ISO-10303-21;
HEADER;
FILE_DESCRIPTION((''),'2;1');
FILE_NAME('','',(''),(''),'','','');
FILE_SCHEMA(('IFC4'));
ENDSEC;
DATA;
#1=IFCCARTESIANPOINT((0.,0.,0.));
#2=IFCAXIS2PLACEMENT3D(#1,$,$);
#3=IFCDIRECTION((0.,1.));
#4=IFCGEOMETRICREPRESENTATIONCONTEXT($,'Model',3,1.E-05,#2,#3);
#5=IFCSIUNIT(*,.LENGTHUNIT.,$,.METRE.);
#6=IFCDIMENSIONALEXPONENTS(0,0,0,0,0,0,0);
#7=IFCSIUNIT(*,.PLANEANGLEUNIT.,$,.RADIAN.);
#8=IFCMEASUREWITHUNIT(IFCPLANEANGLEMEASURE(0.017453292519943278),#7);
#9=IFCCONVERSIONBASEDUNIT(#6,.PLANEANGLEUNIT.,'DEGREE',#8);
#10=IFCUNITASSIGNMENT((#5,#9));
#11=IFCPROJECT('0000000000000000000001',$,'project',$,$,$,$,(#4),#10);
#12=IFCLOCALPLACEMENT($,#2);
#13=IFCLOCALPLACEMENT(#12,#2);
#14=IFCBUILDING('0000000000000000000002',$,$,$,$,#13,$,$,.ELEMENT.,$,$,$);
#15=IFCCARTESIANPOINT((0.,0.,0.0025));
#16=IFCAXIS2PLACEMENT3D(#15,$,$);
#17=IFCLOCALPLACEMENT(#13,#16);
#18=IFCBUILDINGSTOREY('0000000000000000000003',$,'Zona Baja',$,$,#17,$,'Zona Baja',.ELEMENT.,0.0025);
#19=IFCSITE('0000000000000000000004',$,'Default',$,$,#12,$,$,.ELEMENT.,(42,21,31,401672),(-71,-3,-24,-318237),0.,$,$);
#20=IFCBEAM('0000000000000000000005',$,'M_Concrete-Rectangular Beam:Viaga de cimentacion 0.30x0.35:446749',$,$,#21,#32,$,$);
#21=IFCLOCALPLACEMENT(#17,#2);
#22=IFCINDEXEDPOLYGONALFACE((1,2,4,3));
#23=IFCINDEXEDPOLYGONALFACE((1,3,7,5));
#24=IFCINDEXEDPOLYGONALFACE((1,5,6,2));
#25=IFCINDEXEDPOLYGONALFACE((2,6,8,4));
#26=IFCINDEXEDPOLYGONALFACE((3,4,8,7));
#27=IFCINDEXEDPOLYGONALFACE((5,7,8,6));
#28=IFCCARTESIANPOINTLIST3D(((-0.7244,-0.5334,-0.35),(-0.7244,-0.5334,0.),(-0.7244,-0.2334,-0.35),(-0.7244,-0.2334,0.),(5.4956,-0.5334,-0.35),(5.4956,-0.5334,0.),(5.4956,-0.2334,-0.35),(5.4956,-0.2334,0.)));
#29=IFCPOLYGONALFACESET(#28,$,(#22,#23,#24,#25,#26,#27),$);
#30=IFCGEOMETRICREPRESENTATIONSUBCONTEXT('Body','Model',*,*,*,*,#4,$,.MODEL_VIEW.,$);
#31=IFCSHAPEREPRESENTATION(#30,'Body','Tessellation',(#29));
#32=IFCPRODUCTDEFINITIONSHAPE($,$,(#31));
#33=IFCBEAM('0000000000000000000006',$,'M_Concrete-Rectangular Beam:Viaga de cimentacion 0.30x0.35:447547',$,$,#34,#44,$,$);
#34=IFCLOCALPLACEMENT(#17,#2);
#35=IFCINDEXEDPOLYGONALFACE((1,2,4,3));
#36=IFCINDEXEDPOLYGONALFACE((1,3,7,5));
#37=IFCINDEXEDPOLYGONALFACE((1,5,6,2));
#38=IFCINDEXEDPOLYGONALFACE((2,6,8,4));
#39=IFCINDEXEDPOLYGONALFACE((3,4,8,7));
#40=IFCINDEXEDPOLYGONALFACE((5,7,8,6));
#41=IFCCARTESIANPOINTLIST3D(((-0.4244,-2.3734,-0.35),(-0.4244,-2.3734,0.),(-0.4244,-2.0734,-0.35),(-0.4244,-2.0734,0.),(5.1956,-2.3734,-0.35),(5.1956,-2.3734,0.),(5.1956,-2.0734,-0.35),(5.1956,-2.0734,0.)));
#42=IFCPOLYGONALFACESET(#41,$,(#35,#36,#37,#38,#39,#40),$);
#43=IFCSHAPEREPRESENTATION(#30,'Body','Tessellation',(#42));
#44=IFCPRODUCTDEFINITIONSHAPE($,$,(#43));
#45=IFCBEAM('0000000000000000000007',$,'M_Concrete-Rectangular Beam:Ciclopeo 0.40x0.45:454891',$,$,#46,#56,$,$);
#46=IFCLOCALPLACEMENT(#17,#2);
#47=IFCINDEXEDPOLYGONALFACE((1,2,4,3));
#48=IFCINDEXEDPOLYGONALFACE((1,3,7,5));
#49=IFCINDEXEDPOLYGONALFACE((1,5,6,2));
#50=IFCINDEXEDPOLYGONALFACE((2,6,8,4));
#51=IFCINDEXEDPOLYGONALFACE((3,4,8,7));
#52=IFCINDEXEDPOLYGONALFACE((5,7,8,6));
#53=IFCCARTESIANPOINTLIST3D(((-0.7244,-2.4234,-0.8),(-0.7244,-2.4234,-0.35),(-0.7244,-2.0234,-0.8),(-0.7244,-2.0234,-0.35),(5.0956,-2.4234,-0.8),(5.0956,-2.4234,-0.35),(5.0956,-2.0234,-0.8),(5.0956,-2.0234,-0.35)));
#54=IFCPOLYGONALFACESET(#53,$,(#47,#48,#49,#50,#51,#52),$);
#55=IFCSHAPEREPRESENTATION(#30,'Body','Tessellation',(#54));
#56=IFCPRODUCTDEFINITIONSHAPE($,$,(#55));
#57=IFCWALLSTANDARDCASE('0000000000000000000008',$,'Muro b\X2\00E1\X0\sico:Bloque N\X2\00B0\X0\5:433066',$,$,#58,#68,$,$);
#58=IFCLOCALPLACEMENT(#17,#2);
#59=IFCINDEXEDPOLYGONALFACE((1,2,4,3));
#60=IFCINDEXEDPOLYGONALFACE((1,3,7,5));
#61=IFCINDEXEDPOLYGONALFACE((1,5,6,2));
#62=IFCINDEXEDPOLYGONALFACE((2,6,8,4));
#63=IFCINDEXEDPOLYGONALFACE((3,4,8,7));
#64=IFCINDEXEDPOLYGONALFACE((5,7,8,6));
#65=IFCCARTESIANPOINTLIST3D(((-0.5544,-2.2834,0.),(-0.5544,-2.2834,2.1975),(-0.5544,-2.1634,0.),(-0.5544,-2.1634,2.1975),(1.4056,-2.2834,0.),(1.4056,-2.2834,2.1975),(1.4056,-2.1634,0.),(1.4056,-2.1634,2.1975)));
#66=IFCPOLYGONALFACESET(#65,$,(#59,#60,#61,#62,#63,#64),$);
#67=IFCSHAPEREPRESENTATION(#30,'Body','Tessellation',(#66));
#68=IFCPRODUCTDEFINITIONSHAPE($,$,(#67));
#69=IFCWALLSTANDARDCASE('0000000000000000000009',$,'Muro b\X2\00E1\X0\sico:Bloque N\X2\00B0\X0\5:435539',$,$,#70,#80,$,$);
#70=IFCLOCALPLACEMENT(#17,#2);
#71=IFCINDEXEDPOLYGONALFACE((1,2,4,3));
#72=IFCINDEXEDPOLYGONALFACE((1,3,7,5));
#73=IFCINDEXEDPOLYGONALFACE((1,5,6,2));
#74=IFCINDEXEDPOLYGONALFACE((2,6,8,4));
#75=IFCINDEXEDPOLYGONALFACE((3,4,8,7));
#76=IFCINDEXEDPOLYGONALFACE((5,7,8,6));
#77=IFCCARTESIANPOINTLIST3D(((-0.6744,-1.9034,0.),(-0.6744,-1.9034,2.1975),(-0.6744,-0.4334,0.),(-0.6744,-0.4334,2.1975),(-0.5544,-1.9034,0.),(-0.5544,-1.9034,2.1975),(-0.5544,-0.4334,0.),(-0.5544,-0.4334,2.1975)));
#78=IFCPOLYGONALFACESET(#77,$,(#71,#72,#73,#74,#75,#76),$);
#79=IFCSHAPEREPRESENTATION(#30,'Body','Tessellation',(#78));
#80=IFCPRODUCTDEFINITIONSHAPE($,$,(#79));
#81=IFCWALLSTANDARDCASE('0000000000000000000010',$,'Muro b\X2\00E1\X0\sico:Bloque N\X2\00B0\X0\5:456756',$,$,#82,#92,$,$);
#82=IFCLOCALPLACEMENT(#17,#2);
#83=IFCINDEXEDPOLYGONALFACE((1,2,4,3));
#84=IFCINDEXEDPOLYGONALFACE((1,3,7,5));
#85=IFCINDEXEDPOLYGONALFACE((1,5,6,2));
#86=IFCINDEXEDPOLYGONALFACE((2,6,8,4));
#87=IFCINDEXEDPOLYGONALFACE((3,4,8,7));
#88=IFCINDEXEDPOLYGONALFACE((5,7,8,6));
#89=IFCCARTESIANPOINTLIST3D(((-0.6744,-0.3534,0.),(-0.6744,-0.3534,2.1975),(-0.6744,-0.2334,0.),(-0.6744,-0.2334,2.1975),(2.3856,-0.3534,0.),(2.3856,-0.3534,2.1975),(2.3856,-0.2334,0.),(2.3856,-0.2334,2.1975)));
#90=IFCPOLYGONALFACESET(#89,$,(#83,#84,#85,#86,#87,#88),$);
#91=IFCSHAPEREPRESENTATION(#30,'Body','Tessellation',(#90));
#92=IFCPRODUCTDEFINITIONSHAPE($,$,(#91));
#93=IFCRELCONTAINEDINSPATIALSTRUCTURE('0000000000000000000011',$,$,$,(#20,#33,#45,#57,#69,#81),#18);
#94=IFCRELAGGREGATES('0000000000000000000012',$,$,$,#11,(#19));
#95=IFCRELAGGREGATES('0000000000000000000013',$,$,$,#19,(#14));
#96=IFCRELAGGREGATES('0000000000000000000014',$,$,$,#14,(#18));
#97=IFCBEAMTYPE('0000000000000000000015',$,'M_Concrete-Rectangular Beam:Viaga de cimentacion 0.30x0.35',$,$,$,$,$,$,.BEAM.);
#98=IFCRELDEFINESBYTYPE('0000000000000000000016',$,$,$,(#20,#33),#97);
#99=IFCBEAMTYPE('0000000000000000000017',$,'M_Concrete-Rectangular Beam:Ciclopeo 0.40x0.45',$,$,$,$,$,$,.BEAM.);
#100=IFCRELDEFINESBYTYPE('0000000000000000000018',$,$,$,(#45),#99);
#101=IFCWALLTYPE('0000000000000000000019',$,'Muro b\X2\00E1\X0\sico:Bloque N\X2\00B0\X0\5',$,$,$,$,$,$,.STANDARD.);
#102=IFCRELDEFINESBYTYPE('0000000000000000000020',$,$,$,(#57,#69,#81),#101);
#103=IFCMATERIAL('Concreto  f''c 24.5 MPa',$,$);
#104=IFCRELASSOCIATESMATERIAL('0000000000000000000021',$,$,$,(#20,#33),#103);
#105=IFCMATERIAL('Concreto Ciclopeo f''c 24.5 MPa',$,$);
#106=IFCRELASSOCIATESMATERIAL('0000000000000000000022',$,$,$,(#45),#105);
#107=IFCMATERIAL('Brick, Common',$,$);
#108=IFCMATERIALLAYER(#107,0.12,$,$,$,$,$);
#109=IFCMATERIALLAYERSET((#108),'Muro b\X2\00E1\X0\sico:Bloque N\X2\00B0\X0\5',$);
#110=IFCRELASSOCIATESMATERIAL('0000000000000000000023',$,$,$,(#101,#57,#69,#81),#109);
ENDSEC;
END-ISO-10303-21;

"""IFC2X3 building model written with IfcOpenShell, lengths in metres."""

from ifc_helpers import new_model, entity, si_unit, converted_unit, direction, frame, frame_2d, origin, place, context, subcontext, project, spatial, rectangle, extrude, material, layer, layer_set, layer_usage, type_object, element, save


model = new_model("IFC2X3")

# Units and contexts
model_context = context("Model", 3, precision=1e-05, world=origin(), true_north=direction((0.0, 1.0)))
body_context = subcontext(model_context, "Body", "Model", "MODEL_VIEW")
ifc_project = project(units=[si_unit("LENGTHUNIT", "METRE"), converted_unit("PLANEANGLEUNIT", "DEGREE", entity("IfcPlaneAngleMeasure", 0.017453292519943278), si_unit("PLANEANGLEUNIT", "RADIAN"), dimensions=[0, 0, 0, 0, 0, 0, 0])], contexts=[model_context])

# Site, building, storey
site_placement = place(None, origin())
site = spatial("IfcSite", under=ifc_project, at=site_placement, Name="Default", CompositionType="ELEMENT", RefLatitude=(42, 21, 31, 401672), RefLongitude=(-71, -3, -24, -318237), RefElevation=0.0)
building_placement = place(site_placement, origin())
building = spatial("IfcBuilding", under=site, at=building_placement, CompositionType="ELEMENT")
storey_placement = place(building_placement, frame((0.0, 0.0, 0.0025)))
storey = spatial("IfcBuildingStorey", under=building, at=storey_placement, Name="Zona Baja", LongName="Zona Baja", CompositionType="ELEMENT", Elevation=0.0025)

# Beams
ifc_material_1 = material(Name="Concreto  f'c 24.5 MPa")
beam_type_1 = type_object("IfcBeamType", Name="M_Concrete-Rectangular Beam:Viaga de cimentacion 0.30x0.35", PredefinedType="BEAM")
beam_1_placement = place(storey_placement, frame((-0.5744, -0.3834, 0.0)))
element("IfcBeam", 1, at=beam_1_placement, inside=storey, type_object=beam_type_1, material=ifc_material_1, Name="M_Concrete-Rectangular Beam:Viaga de cimentacion 0.30x0.35:446749", context=body_context, shape_type="SweptSolid", body=[
    extrude(rectangle(XDim=0.35, YDim=0.3, at=frame_2d((0.0, 0.0), x_axis=(1.0, 0.0))), frame((-0.15, 0.0, -0.175), z_axis=(1.0, 0.0, 0.0), x_axis=(0.0, 0.0, -1.0)), (0.0, 0.0, 1.0), 6.22),
])
beam_2_placement = place(storey_placement, frame((-0.5744, -2.2234, 0.0)))
element("IfcBeam", 2, at=beam_2_placement, inside=storey, type_object=beam_type_1, material=ifc_material_1, Name="M_Concrete-Rectangular Beam:Viaga de cimentacion 0.30x0.35:447547", context=body_context, shape_type="SweptSolid", body=[
    extrude(rectangle(XDim=0.35, YDim=0.3, at=frame_2d((0.0, 0.0), x_axis=(1.0, 0.0))), frame((0.15, 0.0, -0.175), z_axis=(1.0, 0.0, 0.0), x_axis=(0.0, 0.0, -1.0)), (0.0, 0.0, 1.0), 5.62),
])
ifc_material_2 = material(Name="Concreto Ciclopeo f'c 24.5 MPa")
beam_type_2 = type_object("IfcBeamType", Name="M_Concrete-Rectangular Beam:Ciclopeo 0.40x0.45", PredefinedType="BEAM")
beam_3_placement = place(storey_placement, frame((-0.5244, -2.2234, -0.35)))
element("IfcBeam", 3, at=beam_3_placement, inside=storey, type_object=beam_type_2, material=ifc_material_2, Name="M_Concrete-Rectangular Beam:Ciclopeo 0.40x0.45:454891", context=body_context, shape_type="SweptSolid", body=[
    extrude(rectangle(XDim=0.45, YDim=0.4, at=frame_2d((0.0, 0.0), x_axis=(1.0, 0.0))), frame((-0.2, 0.0, -0.225), z_axis=(1.0, 0.0, 0.0), x_axis=(0.0, 0.0, -1.0)), (0.0, 0.0, 1.0), 5.82),
])

# Walls
ifc_material_3 = material(Name="Brick, Common")
ifc_layer = layer(ifc_material_3, 0.12)
ifc_layer_set = layer_set([ifc_layer], Name="Muro básico:Bloque N°5")
ifc_layer_usage_1 = layer_usage(ifc_layer_set, "AXIS2", "NEGATIVE", 0.06)
wall_type = type_object("IfcWallType", Name="Muro básico:Bloque N°5", PredefinedType="STANDARD", material=ifc_layer_set)
wall_1_placement = place(storey_placement, frame((-0.5544, -2.2234, 0.0)))
element("IfcWallStandardCase", 4, at=wall_1_placement, inside=storey, type_object=wall_type, material=ifc_layer_usage_1, Name="Muro básico:Bloque N°5:433066", context=body_context, shape_type="SweptSolid", body=[
    extrude(rectangle(XDim=1.96, YDim=0.12, at=frame_2d((0.98, 0.0), x_axis=(-1.0, 0.0))), origin(), (0.0, 0.0, 1.0), 2.1975),
])
ifc_layer_usage_2 = layer_usage(ifc_layer_set, "AXIS2", "NEGATIVE", 0.06)
wall_2_placement = place(storey_placement, frame((-0.6144, -0.4334, 0.0), z_axis=(0.0, 0.0, 1.0), x_axis=(0.0, -1.0, 0.0)))
element("IfcWallStandardCase", 5, at=wall_2_placement, inside=storey, type_object=wall_type, material=ifc_layer_usage_2, Name="Muro básico:Bloque N°5:435539", context=body_context, shape_type="SweptSolid", body=[
    extrude(rectangle(XDim=1.47, YDim=0.12, at=frame_2d((0.735, 0.0), x_axis=(-1.0, 0.0))), origin(), (0.0, 0.0, 1.0), 2.1975),
])
ifc_layer_usage_3 = layer_usage(ifc_layer_set, "AXIS2", "NEGATIVE", 0.06)
wall_3_placement = place(storey_placement, frame((-0.6744, -0.2934, 0.0)))
element("IfcWallStandardCase", 6, at=wall_3_placement, inside=storey, type_object=wall_type, material=ifc_layer_usage_3, Name="Muro básico:Bloque N°5:456756", context=body_context, shape_type="SweptSolid", body=[
    extrude(rectangle(XDim=3.06, YDim=0.12, at=frame_2d((1.53, 0.0), x_axis=(-1.0, 0.0))), origin(), (0.0, 0.0, 1.0), 2.1975),
])

save(model, "model.ifc")
